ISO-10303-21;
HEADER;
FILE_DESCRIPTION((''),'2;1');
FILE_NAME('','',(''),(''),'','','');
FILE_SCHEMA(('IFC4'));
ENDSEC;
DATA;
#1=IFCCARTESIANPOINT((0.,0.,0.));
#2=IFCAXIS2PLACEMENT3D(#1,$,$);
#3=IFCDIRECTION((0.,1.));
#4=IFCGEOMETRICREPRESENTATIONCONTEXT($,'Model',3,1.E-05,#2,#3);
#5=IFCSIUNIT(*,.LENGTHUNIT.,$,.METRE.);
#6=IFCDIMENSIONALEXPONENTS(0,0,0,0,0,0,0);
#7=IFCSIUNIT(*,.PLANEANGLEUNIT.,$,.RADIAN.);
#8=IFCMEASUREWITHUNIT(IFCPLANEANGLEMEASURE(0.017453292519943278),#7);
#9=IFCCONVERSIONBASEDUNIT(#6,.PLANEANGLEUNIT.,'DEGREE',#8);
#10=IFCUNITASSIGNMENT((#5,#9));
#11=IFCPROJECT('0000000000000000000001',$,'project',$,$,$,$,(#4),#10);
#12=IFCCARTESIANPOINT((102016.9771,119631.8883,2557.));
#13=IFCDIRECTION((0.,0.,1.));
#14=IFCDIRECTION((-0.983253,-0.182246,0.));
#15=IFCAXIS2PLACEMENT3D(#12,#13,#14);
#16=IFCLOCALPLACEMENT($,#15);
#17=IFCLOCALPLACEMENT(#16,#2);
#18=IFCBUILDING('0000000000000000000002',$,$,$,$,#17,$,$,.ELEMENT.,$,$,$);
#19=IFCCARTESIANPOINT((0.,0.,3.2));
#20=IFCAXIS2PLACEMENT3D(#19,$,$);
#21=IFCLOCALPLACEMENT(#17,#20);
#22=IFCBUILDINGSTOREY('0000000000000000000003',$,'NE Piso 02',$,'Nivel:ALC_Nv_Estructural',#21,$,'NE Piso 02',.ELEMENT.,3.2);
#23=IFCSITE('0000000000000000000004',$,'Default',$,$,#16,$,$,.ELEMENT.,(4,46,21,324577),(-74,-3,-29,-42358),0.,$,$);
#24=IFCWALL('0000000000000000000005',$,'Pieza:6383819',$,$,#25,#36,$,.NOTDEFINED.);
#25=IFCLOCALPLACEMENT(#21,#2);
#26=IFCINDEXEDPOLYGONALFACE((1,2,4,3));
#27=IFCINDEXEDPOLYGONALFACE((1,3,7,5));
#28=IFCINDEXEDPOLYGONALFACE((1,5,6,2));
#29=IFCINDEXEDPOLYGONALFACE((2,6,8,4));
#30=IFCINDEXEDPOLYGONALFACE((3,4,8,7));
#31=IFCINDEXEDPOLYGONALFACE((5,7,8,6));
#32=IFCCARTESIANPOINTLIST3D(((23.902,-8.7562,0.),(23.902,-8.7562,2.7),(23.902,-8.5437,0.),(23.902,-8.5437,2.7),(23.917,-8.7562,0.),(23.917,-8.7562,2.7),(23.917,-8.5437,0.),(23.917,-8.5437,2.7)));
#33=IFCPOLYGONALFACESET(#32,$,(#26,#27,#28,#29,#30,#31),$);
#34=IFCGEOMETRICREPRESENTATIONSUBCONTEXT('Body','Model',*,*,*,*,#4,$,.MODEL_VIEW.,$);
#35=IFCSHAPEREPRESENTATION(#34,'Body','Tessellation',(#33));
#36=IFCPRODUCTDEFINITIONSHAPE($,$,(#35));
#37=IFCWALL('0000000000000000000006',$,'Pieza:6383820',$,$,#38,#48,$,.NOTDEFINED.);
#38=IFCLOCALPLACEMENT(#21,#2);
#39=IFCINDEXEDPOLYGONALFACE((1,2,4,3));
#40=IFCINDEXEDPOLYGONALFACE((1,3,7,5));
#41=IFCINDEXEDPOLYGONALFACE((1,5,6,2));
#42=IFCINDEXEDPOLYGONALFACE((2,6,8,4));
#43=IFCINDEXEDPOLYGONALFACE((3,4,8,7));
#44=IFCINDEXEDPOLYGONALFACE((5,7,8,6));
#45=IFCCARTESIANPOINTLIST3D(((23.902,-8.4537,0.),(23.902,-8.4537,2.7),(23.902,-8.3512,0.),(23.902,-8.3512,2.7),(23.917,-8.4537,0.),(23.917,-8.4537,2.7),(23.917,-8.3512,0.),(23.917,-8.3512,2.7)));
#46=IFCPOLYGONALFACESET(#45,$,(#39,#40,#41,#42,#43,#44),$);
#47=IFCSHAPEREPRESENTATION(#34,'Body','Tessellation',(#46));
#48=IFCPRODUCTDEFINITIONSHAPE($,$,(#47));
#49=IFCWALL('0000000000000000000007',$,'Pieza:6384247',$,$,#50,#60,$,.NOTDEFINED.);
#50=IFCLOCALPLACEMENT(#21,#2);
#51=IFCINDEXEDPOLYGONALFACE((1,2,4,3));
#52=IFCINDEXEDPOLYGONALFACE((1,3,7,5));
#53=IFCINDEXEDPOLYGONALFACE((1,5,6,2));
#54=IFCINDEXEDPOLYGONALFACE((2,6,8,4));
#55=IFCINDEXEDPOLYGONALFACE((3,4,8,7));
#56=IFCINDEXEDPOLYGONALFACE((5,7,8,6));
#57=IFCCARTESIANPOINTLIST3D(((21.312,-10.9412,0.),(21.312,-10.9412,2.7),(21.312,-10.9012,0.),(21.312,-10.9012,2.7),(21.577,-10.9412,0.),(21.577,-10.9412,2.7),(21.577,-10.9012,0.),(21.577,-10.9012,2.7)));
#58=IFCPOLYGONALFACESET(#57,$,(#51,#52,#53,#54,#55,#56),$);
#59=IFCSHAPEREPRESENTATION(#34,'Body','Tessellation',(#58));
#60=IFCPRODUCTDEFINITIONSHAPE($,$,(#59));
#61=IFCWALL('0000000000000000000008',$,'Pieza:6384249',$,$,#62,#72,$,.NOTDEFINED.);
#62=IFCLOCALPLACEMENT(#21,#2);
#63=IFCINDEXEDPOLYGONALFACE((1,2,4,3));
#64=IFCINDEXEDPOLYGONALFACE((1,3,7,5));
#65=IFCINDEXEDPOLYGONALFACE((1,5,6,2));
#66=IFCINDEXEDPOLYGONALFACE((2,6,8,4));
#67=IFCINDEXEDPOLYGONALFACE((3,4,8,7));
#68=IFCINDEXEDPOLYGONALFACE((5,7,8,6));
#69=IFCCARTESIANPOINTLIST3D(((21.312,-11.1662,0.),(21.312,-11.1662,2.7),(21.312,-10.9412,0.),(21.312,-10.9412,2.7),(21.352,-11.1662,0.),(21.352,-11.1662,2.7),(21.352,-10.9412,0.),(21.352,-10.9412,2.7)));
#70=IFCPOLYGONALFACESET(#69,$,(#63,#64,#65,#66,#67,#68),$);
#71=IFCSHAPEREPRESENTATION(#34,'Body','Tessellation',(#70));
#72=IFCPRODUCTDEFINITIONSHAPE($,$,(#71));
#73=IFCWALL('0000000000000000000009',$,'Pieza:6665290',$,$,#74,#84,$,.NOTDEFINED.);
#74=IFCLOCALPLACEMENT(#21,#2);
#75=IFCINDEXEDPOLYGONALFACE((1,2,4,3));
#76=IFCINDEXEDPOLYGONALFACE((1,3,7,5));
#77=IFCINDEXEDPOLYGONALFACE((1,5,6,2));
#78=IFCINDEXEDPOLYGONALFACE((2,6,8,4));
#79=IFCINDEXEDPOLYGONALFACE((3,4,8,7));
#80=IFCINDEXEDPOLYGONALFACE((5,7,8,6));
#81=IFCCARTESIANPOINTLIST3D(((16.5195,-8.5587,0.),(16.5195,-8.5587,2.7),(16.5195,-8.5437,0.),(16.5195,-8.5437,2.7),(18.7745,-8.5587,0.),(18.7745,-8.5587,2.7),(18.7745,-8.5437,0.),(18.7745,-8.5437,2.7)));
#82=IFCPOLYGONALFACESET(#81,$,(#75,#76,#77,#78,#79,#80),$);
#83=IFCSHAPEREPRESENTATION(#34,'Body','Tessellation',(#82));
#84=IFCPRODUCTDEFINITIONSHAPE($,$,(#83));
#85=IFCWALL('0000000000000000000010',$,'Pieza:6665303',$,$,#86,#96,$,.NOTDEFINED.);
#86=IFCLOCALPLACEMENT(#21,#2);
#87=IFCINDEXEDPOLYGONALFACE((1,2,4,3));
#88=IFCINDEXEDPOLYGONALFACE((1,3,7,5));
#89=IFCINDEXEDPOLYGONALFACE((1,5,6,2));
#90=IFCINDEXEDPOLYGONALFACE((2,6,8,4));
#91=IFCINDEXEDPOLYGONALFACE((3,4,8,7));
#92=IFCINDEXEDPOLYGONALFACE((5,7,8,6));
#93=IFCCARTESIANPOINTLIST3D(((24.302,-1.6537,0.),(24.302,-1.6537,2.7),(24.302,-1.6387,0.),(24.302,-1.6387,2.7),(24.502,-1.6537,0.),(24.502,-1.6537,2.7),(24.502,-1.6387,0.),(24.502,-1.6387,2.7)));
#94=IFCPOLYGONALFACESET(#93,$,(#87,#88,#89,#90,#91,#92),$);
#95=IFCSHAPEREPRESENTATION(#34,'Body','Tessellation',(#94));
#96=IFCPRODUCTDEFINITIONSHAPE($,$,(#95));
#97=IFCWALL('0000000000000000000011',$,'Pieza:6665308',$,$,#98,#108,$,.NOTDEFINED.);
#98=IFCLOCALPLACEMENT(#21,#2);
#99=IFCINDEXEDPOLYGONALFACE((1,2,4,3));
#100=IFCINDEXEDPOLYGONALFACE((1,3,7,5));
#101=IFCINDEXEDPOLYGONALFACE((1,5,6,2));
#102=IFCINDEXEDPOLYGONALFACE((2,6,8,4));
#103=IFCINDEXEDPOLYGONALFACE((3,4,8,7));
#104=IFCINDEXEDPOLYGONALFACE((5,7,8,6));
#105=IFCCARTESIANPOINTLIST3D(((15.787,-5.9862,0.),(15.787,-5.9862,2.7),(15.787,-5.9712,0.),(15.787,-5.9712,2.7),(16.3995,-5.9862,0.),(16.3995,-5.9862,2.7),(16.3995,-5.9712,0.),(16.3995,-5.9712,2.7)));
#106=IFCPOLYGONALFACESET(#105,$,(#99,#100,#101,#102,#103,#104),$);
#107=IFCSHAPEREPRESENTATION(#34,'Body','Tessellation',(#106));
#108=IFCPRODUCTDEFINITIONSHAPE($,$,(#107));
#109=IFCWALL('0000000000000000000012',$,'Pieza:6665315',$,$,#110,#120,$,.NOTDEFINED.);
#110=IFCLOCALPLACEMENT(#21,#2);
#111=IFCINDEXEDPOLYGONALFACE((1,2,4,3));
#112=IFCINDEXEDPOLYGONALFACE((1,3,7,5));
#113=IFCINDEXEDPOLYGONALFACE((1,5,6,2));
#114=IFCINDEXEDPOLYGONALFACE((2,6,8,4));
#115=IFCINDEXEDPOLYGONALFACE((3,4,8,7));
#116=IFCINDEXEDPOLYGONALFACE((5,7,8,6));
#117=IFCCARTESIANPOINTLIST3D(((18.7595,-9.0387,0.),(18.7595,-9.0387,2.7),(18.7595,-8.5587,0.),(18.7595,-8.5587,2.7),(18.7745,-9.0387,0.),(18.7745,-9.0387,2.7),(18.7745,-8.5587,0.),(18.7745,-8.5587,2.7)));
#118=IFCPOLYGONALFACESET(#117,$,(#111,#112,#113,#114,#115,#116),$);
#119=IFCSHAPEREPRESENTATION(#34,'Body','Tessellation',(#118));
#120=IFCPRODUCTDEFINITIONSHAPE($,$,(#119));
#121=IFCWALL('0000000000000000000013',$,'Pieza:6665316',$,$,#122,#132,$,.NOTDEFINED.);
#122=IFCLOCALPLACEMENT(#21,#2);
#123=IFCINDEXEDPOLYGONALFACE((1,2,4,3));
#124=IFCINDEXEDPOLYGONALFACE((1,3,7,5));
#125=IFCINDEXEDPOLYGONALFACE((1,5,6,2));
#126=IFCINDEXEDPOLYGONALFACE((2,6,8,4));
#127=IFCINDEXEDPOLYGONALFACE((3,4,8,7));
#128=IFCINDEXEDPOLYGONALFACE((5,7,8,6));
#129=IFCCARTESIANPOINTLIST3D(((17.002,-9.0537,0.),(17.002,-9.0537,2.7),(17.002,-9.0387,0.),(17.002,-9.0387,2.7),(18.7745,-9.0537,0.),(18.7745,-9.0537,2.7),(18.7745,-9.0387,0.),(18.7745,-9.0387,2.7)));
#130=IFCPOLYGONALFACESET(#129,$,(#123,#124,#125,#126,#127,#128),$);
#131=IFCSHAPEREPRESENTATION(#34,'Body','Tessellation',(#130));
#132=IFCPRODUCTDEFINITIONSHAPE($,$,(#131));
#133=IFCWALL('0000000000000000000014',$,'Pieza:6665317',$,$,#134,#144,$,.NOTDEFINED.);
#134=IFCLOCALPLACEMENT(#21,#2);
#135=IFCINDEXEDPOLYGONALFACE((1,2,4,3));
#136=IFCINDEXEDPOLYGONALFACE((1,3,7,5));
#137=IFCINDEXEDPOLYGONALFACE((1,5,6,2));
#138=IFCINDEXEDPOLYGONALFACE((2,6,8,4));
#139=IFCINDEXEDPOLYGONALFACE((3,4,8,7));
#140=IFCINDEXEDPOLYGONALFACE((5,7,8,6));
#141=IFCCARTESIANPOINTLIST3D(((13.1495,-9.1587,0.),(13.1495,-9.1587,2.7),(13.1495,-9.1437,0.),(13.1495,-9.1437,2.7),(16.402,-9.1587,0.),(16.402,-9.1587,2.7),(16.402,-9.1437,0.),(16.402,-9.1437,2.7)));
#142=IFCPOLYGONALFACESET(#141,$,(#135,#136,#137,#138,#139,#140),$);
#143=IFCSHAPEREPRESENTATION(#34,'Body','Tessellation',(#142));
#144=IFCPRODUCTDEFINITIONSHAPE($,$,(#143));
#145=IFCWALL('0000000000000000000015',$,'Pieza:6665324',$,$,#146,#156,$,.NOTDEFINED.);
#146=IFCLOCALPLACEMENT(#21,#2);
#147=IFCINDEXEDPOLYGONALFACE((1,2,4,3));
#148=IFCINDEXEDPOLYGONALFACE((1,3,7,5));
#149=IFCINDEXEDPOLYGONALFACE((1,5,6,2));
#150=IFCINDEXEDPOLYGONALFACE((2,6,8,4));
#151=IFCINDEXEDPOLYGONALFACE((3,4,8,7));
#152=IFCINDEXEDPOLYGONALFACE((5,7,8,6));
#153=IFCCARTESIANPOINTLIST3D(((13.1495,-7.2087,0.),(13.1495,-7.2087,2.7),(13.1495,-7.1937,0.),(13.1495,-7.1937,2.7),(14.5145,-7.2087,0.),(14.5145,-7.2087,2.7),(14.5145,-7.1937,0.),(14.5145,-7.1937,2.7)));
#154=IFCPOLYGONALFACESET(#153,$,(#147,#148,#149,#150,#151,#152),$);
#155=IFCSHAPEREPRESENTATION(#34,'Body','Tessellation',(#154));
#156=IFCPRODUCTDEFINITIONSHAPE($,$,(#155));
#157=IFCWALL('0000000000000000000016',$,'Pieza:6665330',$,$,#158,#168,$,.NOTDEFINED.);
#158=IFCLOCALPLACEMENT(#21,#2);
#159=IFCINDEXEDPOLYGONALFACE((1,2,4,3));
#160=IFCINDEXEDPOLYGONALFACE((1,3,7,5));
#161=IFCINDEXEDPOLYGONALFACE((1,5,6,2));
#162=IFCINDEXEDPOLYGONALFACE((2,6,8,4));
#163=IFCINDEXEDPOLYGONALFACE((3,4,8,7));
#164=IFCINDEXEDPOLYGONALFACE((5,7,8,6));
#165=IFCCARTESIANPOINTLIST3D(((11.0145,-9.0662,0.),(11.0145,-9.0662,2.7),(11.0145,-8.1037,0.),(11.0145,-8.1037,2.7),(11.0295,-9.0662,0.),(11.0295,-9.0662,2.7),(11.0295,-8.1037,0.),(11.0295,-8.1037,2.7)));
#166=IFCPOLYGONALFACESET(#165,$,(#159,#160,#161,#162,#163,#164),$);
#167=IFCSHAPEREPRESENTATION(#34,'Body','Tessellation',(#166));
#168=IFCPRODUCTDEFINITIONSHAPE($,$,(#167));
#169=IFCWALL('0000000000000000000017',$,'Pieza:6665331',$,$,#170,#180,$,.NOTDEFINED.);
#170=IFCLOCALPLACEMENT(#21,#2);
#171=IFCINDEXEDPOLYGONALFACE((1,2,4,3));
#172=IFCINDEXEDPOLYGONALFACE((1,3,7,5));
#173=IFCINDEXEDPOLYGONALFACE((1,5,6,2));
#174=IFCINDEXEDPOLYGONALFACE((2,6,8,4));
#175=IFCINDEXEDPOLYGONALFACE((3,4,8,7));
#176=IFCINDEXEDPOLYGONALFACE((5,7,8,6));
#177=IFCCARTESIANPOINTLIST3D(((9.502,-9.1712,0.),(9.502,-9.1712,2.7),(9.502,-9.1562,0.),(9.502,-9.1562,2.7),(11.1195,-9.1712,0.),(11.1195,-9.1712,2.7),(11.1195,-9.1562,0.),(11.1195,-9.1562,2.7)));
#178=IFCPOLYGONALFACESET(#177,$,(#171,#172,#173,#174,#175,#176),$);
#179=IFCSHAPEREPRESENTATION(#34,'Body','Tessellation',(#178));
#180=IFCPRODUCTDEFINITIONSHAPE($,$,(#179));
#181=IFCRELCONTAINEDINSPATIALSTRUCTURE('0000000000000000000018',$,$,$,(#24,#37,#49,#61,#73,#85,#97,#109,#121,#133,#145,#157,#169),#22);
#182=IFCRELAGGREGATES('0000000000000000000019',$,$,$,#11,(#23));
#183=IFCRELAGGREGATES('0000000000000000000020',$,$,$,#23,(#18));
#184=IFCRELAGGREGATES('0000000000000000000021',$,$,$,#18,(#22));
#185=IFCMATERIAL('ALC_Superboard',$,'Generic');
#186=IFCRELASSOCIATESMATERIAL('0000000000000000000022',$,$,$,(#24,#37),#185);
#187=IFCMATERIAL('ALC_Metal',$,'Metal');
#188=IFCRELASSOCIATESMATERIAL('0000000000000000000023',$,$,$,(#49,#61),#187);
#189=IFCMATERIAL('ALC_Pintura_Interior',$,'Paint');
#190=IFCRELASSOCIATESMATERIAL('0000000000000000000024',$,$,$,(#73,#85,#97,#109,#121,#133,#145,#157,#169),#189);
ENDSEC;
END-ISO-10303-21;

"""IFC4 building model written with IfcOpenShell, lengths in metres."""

from ifc_helpers import new_model, entity, si_unit, converted_unit, direction, frame, frame_2d, origin, origin_2d_with_axis, place, context, subcontext, project, spatial, rectangle, extrude, material, element, save


model = new_model("IFC4")

# Units and contexts
model_context = context("Model", 3, precision=1e-05, world=origin(), true_north=direction((0.0, 1.0)))
body_context = subcontext(model_context, "Body", "Model", "MODEL_VIEW")
ifc_project = project(units=[si_unit("LENGTHUNIT", "METRE"), converted_unit("PLANEANGLEUNIT", "DEGREE", entity("IfcPlaneAngleMeasure", 0.017453292519943278), si_unit("PLANEANGLEUNIT", "RADIAN"), dimensions=[0, 0, 0, 0, 0, 0, 0])], contexts=[model_context])

# Site, building, storey
site_placement = place(None, frame((102016.9771, 119631.8883, 2557.0), z_axis=(0.0, 0.0, 1.0), x_axis=(-0.983253, -0.182246, 0.0)))
site = spatial("IfcSite", under=ifc_project, at=site_placement, Name="Default", CompositionType="ELEMENT", RefLatitude=(4, 46, 21, 324577), RefLongitude=(-74, -3, -29, -42358), RefElevation=0.0)
building_placement = place(site_placement, origin())
building = spatial("IfcBuilding", under=site, at=building_placement, CompositionType="ELEMENT")
storey_placement = place(building_placement, frame((0.0, 0.0, 3.2)))
storey = spatial("IfcBuildingStorey", under=building, at=storey_placement, Name="NE Piso 02", ObjectType="Nivel:ALC_Nv_Estructural", LongName="NE Piso 02", CompositionType="ELEMENT", Elevation=3.2)

# Walls
ifc_material_1 = material(Name="ALC_Superboard", Category="Generic")
wall_1_placement = place(storey_placement, origin())
element("IfcWall", 1, at=wall_1_placement, inside=storey, material=ifc_material_1, Name="Pieza:6383819", PredefinedType="NOTDEFINED", context=body_context, shape_type="SweptSolid", body=[
    extrude(rectangle(XDim=0.2125, YDim=0.015, at=frame_2d((0.0, 0.0), x_axis=(1.0, 0.0))), frame((23.9095, -8.6499, 0.0), z_axis=(0.0, 0.0, 1.0), x_axis=(0.0, -1.0, 0.0)), (0.0, 0.0, 1.0), 2.7),
])
wall_2_placement = place(storey_placement, origin())
element("IfcWall", 2, at=wall_2_placement, inside=storey, material=ifc_material_1, Name="Pieza:6383820", PredefinedType="NOTDEFINED", context=body_context, shape_type="SweptSolid", body=[
    extrude(rectangle(XDim=0.1025, YDim=0.015, at=frame_2d((0.0, 0.0), x_axis=(1.0, 0.0))), frame((23.9095, -8.4024, 0.0), z_axis=(0.0, 0.0, 1.0), x_axis=(0.0, -1.0, 0.0)), (0.0, 0.0, 1.0), 2.7),
])
ifc_material_2 = material(Name="ALC_Metal", Category="Metal")
wall_3_placement = place(storey_placement, origin())
element("IfcWall", 3, at=wall_3_placement, inside=storey, material=ifc_material_2, Name="Pieza:6384247", PredefinedType="NOTDEFINED", context=body_context, shape_type="SweptSolid", body=[
    extrude(rectangle(XDim=0.04, YDim=0.265, at=frame_2d((0.0, 0.0), x_axis=(1.0, 0.0))), frame((21.4445, -10.9212, 0.0), z_axis=(0.0, 0.0, 1.0), x_axis=(0.0, -1.0, 0.0)), (0.0, 0.0, 1.0), 2.7),
])
wall_4_placement = place(storey_placement, origin())
element("IfcWall", 4, at=wall_4_placement, inside=storey, material=ifc_material_2, Name="Pieza:6384249", PredefinedType="NOTDEFINED", context=body_context, shape_type="SweptSolid", body=[
    extrude(rectangle(XDim=0.225, YDim=0.04, at=frame_2d((0.0, 0.0), x_axis=(1.0, 0.0))), frame((21.332, -11.0537, 0.0), z_axis=(0.0, 0.0, 1.0), x_axis=(0.0, -1.0, 0.0)), (0.0, 0.0, 1.0), 2.7),
])

# Walls
ifc_material_3 = material(Name="ALC_Pintura_Interior", Category="Paint")
wall_5_placement = place(storey_placement, origin())
element("IfcWall", 5, at=wall_5_placement, inside=storey, material=ifc_material_3, Name="Pieza:6665290", PredefinedType="NOTDEFINED", context=body_context, shape_type="SweptSolid", body=[
    extrude(rectangle(XDim=0.015, YDim=2.255, at=frame_2d((0.0, 0.0), x_axis=(1.0, 0.0))), frame((17.647, -8.5512, 0.0), z_axis=(0.0, 0.0, 1.0), x_axis=(0.0, -1.0, 0.0)), (0.0, 0.0, 1.0), 2.7),
])
wall_6_placement = place(storey_placement, origin())
element("IfcWall", 6, at=wall_6_placement, inside=storey, material=ifc_material_3, Name="Pieza:6665303", PredefinedType="NOTDEFINED", context=body_context, shape_type="SweptSolid", body=[
    extrude(rectangle(XDim=0.015, YDim=0.2, at=frame_2d((0.0, 0.0), x_axis=(1.0, 0.0))), frame((24.402, -1.6462, 0.0), z_axis=(0.0, 0.0, 1.0), x_axis=(0.0, -1.0, 0.0)), (0.0, 0.0, 1.0), 2.7),
])
wall_7_placement = place(storey_placement, origin())
element("IfcWall", 7, at=wall_7_placement, inside=storey, material=ifc_material_3, Name="Pieza:6665308", PredefinedType="NOTDEFINED", context=body_context, shape_type="SweptSolid", body=[
    extrude(rectangle(XDim=0.015, YDim=0.6125, at=frame_2d((0.0, 0.0), x_axis=(1.0, 0.0))), frame((16.0933, -5.9787, 0.0), z_axis=(0.0, 0.0, 1.0), x_axis=(0.0, -1.0, 0.0)), (0.0, 0.0, 1.0), 2.7),
])
wall_8_placement = place(storey_placement, origin())
element("IfcWall", 8, at=wall_8_placement, inside=storey, material=ifc_material_3, Name="Pieza:6665315", PredefinedType="NOTDEFINED", context=body_context, shape_type="SweptSolid", body=[
    extrude(rectangle(XDim=0.48, YDim=0.015, at=frame_2d((0.0, 0.0), x_axis=(1.0, 0.0))), frame((18.767, -8.7987, 0.0), z_axis=(0.0, 0.0, 1.0), x_axis=(0.0, -1.0, 0.0)), (0.0, 0.0, 1.0), 2.7),
])
wall_9_placement = place(storey_placement, origin())
element("IfcWall", 9, at=wall_9_placement, inside=storey, material=ifc_material_3, Name="Pieza:6665316", PredefinedType="NOTDEFINED", context=body_context, shape_type="SweptSolid", body=[
    extrude(rectangle(XDim=0.015, YDim=1.7725, at=frame_2d((0.0, 0.0), x_axis=(1.0, 0.0))), frame((17.8883, -9.0462, 0.0), z_axis=(0.0, 0.0, 1.0), x_axis=(0.0, -1.0, 0.0)), (0.0, 0.0, 1.0), 2.7),
])
wall_10_placement = place(storey_placement, origin())
element("IfcWall", 10, at=wall_10_placement, inside=storey, material=ifc_material_3, Name="Pieza:6665317", PredefinedType="NOTDEFINED", context=body_context, shape_type="SweptSolid", body=[
    extrude(rectangle(XDim=0.015, YDim=3.2525, at=frame_2d((0.0, 0.0), x_axis=(1.0, 0.0))), frame((14.7758, -9.1512, 0.0), z_axis=(0.0, 0.0, 1.0), x_axis=(0.0, -1.0, 0.0)), (0.0, 0.0, 1.0), 2.7),
])
wall_11_placement = place(storey_placement, origin())
element("IfcWall", 11, at=wall_11_placement, inside=storey, material=ifc_material_3, Name="Pieza:6665324", PredefinedType="NOTDEFINED", context=body_context, shape_type="SweptSolid", body=[
    extrude(rectangle(XDim=0.015, YDim=1.365, at=frame_2d((0.0, 0.0), x_axis=(1.0, 0.0))), frame((13.832, -7.2012, 0.0), z_axis=(0.0, 0.0, 1.0), x_axis=(0.0, -1.0, 0.0)), (0.0, 0.0, 1.0), 2.7),
])
wall_12_placement = place(storey_placement, origin())
element("IfcWall", 12, at=wall_12_placement, inside=storey, material=ifc_material_3, Name="Pieza:6665330", PredefinedType="NOTDEFINED", context=body_context, shape_type="SweptSolid", body=[
    extrude(rectangle(XDim=0.9625, YDim=0.015, at=origin_2d_with_axis()), frame((11.022, -8.5849, 0.0), z_axis=(0.0, 0.0, 1.0), x_axis=(0.0, -1.0, 0.0)), (0.0, 0.0, 1.0), 2.7),
])
wall_13_placement = place(storey_placement, origin())
element("IfcWall", 13, at=wall_13_placement, inside=storey, material=ifc_material_3, Name="Pieza:6665331", PredefinedType="NOTDEFINED", context=body_context, shape_type="SweptSolid", body=[
    extrude(rectangle(XDim=0.015, YDim=1.6175, at=frame_2d((0.0, 0.0), x_axis=(1.0, 0.0))), frame((10.3108, -9.1637, 0.0), z_axis=(0.0, 0.0, 1.0), x_axis=(0.0, -1.0, 0.0)), (0.0, 0.0, 1.0), 2.7),
])

save(model, "model.ifc")
